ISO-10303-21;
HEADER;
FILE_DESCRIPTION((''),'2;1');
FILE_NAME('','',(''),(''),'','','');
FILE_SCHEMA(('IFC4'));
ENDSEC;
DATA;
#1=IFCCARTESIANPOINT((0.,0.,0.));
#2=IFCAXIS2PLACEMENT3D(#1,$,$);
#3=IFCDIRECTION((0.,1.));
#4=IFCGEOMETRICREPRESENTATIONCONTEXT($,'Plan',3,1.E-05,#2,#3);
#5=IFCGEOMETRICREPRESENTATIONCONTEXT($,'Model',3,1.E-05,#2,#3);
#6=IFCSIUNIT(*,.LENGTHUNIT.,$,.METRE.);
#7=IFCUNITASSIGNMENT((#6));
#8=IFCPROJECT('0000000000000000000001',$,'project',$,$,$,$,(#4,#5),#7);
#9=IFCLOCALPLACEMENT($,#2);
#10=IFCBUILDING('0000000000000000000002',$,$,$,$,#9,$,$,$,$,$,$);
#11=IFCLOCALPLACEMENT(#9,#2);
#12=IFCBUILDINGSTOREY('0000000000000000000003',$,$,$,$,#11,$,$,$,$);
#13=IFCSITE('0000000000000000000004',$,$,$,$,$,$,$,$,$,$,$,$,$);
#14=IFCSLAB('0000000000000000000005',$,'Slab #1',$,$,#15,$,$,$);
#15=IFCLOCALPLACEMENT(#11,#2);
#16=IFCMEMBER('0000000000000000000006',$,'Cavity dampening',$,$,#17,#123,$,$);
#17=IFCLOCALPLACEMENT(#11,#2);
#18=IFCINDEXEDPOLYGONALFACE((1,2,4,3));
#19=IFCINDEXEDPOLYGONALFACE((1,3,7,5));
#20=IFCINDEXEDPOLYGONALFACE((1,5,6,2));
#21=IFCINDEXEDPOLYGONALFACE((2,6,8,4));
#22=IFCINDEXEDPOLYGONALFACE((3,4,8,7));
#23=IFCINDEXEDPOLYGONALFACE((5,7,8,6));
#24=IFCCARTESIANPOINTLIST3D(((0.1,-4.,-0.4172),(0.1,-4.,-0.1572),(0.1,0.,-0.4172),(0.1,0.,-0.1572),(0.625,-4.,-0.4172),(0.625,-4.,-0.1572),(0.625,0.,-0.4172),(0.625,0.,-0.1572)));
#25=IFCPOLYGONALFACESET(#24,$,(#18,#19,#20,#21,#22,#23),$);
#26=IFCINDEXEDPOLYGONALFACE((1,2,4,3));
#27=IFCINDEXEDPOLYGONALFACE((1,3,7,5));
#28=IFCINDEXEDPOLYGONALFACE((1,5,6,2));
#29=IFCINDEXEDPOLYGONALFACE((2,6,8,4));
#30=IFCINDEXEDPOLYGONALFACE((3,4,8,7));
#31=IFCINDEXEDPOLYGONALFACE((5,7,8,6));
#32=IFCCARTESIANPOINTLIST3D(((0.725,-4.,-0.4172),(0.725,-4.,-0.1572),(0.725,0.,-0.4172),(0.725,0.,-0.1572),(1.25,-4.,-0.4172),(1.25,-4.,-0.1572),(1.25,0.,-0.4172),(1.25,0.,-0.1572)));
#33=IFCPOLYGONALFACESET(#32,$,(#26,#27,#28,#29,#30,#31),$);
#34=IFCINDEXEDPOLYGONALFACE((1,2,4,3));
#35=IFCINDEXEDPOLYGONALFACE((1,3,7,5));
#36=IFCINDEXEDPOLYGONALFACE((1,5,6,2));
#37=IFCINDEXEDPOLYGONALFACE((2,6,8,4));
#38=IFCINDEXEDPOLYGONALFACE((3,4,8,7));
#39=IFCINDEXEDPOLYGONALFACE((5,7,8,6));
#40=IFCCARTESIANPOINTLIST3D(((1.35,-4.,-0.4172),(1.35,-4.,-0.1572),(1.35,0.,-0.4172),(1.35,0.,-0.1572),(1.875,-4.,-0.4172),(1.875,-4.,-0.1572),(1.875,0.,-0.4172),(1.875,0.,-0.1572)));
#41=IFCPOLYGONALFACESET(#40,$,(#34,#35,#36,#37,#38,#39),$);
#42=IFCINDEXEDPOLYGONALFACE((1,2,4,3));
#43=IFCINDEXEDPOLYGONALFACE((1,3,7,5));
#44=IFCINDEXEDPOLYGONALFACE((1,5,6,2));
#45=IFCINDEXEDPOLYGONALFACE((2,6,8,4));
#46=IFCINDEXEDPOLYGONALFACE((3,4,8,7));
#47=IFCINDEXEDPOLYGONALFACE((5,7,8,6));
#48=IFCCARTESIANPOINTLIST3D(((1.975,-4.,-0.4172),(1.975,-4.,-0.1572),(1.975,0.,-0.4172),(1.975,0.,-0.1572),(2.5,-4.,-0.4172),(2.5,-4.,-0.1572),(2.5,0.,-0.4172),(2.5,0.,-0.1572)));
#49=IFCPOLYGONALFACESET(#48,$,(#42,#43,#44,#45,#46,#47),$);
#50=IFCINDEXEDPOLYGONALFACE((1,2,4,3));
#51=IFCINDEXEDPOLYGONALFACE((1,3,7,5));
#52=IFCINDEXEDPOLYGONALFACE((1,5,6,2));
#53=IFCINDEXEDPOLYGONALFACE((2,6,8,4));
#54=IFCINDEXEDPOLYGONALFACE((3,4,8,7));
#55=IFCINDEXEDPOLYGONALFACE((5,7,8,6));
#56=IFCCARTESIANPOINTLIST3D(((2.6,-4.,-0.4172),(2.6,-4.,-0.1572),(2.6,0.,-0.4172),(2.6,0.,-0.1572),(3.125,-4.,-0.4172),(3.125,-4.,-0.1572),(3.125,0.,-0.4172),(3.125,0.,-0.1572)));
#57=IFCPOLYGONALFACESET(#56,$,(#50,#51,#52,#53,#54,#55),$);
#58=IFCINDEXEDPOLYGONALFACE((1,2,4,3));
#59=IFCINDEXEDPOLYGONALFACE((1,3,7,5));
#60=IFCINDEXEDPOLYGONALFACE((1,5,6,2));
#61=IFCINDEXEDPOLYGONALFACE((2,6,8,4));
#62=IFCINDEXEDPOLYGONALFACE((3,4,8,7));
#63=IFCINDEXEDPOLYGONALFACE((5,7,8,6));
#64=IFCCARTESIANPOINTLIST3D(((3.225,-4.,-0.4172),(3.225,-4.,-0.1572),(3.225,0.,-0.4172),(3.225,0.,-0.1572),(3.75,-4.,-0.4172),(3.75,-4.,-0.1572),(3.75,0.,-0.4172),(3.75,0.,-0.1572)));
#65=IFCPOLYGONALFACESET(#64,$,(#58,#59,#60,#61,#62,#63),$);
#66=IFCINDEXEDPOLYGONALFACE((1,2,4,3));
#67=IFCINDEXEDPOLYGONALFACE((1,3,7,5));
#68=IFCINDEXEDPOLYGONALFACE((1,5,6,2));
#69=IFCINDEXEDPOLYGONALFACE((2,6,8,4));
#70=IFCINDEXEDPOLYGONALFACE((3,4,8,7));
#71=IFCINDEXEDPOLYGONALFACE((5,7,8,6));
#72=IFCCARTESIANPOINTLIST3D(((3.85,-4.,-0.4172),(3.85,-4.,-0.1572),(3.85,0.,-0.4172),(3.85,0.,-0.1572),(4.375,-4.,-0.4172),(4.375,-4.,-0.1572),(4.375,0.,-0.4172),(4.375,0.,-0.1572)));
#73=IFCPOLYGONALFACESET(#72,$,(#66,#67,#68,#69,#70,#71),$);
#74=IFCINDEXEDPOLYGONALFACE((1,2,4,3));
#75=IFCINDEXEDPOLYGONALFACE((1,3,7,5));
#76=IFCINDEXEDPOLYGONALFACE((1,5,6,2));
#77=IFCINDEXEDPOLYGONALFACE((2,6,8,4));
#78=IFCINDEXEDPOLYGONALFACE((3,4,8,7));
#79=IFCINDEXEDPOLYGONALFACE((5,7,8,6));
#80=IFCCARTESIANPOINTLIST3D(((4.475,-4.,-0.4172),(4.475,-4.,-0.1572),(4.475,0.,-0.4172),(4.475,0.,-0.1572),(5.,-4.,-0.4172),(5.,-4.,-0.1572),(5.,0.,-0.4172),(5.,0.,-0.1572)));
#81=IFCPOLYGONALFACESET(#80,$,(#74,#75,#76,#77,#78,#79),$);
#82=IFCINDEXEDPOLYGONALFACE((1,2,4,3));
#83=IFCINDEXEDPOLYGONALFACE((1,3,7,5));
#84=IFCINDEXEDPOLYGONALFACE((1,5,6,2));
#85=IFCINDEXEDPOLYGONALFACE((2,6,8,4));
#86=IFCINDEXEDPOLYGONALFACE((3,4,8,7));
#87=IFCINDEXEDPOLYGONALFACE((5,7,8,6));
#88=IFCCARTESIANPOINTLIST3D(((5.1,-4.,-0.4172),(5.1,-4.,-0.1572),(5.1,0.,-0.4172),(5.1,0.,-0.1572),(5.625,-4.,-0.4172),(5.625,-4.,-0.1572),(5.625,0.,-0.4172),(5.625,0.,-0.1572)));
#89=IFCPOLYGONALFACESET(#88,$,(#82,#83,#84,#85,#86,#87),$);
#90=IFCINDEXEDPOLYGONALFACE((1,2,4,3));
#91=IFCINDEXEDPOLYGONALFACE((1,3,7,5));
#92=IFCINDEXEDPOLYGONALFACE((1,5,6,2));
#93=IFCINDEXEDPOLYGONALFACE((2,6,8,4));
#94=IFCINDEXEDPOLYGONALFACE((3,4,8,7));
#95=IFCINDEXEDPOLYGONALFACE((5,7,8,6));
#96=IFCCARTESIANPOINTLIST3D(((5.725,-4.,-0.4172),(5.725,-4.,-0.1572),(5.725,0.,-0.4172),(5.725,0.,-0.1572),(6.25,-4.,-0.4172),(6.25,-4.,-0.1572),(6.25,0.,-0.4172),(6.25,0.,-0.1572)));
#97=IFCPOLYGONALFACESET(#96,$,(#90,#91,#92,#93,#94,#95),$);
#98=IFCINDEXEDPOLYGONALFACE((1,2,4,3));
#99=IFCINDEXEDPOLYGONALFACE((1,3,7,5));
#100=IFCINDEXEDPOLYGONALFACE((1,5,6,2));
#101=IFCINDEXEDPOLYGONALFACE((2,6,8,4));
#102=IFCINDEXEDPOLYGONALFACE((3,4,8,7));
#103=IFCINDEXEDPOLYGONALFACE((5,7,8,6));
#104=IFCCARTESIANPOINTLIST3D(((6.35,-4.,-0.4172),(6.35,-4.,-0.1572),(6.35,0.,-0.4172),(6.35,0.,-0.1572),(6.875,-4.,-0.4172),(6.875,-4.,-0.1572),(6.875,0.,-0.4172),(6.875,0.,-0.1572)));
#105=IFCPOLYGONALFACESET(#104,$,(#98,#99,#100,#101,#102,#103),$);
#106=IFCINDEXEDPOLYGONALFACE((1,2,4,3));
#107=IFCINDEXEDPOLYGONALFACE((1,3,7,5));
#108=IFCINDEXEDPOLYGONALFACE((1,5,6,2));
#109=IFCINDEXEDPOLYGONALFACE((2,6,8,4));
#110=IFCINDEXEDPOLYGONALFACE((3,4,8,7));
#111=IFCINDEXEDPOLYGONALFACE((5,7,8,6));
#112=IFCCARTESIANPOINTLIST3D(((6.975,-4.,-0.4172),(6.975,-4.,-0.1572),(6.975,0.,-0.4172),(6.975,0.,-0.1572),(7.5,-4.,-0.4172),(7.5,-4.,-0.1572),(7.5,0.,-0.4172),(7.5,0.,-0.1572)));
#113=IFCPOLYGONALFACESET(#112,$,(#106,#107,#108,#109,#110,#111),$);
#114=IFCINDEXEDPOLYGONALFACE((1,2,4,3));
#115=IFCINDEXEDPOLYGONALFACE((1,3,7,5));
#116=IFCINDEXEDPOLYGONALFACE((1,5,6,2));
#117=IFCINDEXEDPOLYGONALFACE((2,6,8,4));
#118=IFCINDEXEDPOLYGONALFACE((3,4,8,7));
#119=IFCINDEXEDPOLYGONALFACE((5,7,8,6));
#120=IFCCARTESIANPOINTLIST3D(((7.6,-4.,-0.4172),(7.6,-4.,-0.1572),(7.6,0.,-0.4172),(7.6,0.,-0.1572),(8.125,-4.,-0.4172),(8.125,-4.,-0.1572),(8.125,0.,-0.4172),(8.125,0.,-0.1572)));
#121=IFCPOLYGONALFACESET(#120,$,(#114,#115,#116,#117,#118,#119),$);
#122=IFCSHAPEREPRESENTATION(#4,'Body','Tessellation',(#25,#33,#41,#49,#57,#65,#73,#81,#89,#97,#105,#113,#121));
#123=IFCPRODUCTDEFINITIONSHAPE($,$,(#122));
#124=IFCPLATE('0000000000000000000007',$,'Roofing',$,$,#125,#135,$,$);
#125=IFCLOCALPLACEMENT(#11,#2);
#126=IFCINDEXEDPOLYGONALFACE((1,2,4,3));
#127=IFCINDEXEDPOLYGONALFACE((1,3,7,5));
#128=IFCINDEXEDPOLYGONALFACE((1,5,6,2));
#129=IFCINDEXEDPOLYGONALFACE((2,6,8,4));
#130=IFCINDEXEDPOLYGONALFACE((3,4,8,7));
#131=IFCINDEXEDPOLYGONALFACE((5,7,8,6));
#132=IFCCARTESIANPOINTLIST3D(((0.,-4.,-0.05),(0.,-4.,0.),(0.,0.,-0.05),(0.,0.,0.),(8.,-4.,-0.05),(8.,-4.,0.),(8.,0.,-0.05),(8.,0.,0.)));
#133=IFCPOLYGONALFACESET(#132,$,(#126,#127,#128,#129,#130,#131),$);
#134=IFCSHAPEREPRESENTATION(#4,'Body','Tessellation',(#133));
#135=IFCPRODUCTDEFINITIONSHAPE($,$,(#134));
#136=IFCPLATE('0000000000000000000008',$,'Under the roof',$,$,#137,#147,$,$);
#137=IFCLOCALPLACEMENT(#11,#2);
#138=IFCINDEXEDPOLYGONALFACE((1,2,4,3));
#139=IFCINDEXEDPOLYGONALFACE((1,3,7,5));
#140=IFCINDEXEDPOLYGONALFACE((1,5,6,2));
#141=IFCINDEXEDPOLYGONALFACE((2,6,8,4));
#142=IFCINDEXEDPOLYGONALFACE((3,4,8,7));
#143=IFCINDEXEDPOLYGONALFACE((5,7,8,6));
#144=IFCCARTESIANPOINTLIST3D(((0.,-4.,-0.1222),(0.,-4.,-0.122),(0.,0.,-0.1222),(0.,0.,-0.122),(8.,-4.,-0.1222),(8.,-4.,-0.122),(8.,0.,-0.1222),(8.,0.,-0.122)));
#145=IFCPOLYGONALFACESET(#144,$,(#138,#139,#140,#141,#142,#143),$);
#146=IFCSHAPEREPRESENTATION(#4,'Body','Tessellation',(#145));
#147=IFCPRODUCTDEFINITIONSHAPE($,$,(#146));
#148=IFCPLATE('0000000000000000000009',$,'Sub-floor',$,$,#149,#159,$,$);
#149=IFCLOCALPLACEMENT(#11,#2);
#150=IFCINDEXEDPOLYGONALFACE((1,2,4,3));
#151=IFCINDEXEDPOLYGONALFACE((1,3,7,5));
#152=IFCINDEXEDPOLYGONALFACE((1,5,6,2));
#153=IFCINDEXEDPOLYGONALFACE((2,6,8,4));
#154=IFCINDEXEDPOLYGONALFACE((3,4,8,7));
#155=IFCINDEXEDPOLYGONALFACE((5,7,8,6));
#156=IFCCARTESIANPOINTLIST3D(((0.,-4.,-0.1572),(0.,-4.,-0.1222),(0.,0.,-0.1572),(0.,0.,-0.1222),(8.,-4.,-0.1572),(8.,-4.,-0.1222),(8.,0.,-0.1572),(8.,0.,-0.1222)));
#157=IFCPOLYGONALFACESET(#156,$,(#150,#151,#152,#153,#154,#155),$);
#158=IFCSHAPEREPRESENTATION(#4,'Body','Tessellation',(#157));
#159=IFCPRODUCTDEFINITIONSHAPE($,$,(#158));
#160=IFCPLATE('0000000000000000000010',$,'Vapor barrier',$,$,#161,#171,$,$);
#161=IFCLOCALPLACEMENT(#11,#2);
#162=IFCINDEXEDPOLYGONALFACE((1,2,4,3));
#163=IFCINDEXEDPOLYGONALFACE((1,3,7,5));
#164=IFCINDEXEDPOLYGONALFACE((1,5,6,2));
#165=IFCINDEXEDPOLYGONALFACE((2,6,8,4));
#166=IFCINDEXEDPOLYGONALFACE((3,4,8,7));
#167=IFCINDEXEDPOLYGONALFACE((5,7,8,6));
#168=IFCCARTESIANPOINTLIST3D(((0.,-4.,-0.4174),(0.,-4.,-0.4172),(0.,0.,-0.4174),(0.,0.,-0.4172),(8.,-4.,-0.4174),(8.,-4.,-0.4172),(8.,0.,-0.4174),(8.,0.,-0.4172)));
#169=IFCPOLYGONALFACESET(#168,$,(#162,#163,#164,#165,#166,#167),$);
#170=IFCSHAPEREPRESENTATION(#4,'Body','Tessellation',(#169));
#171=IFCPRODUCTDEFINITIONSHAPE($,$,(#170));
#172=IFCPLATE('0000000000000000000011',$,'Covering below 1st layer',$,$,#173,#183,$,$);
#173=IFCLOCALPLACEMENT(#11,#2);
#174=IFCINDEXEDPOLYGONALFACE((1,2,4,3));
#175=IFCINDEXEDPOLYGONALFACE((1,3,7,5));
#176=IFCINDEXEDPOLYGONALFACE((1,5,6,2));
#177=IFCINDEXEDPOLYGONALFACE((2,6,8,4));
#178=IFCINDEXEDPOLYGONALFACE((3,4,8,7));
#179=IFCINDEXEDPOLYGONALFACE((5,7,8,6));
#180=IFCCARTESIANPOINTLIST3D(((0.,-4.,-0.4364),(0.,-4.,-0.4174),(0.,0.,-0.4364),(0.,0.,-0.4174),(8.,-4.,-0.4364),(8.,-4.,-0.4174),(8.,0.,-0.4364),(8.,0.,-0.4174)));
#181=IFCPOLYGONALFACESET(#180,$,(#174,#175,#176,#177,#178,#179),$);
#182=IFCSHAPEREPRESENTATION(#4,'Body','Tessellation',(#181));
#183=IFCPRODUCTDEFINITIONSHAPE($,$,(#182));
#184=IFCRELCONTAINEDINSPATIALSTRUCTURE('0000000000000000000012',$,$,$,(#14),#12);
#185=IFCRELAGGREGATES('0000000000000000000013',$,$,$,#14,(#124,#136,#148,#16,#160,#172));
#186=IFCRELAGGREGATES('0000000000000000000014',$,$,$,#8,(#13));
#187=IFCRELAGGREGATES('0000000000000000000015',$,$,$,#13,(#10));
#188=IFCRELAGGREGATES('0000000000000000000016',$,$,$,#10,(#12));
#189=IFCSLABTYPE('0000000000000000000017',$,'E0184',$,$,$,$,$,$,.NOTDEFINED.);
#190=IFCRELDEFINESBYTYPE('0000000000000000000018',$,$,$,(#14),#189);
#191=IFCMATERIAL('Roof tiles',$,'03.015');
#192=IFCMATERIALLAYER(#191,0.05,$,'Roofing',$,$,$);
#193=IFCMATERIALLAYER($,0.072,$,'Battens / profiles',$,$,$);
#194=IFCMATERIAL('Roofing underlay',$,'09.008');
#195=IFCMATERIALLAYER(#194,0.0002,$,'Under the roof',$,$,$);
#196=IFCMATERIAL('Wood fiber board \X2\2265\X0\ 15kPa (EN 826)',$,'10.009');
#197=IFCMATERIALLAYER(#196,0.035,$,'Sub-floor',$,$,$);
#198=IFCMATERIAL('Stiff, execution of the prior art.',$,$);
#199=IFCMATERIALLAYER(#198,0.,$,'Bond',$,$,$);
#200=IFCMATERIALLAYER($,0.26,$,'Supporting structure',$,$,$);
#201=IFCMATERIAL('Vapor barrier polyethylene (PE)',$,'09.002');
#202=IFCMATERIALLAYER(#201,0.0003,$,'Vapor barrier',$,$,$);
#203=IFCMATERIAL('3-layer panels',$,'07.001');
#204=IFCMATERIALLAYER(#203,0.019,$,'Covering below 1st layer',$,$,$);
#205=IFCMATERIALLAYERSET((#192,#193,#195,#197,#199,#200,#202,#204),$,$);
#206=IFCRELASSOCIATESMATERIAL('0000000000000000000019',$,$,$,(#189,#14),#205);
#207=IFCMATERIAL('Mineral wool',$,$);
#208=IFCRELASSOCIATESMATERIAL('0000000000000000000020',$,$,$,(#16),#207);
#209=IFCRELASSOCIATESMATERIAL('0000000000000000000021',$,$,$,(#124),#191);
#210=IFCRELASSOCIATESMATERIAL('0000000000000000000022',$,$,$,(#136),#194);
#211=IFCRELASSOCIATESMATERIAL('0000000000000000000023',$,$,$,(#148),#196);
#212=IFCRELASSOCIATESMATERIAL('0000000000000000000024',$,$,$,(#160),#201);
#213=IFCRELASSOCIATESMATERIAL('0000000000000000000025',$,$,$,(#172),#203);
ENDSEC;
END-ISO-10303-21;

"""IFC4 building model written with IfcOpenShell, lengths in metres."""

from ifc_helpers import new_model, si_unit, direction, frame, frame_2d, origin, origin_with_axes, place, context, project, spatial, rectangle, extrude, material, layer, layer_set, type_object, element, aggregate, save


model = new_model("IFC4")

# Units and contexts
plan_context = context("Plan", 3, precision=1e-05, world=origin(), true_north=direction((0.0, 1.0)))
model_context = context("Model", 3, precision=1e-05, world=origin(), true_north=direction((0.0, 1.0)))
ifc_project = project(units=[si_unit("LENGTHUNIT", "METRE")], contexts=[plan_context, model_context])

# Site, building, storey
site = spatial("IfcSite", under=ifc_project)
building_placement = place(None, origin())
building = spatial("IfcBuilding", under=site, at=building_placement)
storey_placement = place(building_placement, origin())
storey = spatial("IfcBuildingStorey", under=building, at=storey_placement)

# Slab, member, plates
ifc_material_1 = material(Name="Roof tiles", Category="03.015")
ifc_layer_1 = layer(ifc_material_1, 0.05, Name="Roofing")
ifc_layer_2 = layer(None, 0.072, Name="Battens / profiles")
ifc_material_2 = material(Name="Roofing underlay", Category="09.008")
ifc_layer_3 = layer(ifc_material_2, 0.0002, Name="Under the roof")
ifc_material_3 = material(Name="Wood fiber board ≥ 15kPa (EN 826)", Category="10.009")
ifc_layer_4 = layer(ifc_material_3, 0.035, Name="Sub-floor")
ifc_material_4 = material(Name="Stiff, execution of the prior art.")
ifc_layer_5 = layer(ifc_material_4, 0.0, Name="Bond")
ifc_layer_6 = layer(None, 0.26, Name="Supporting structure")
ifc_material_5 = material(Name="Vapor barrier polyethylene (PE)", Category="09.002")
ifc_layer_7 = layer(ifc_material_5, 0.0003, Name="Vapor barrier")
ifc_material_6 = material(Name="3-layer panels", Category="07.001")
ifc_layer_8 = layer(ifc_material_6, 0.019, Name="Covering below 1st layer")
ifc_layer_set = layer_set([ifc_layer_1, ifc_layer_2, ifc_layer_3, ifc_layer_4, ifc_layer_5, ifc_layer_6, ifc_layer_7, ifc_layer_8])
slab_type = type_object("IfcSlabType", Name="E0184", PredefinedType="NOTDEFINED", material=ifc_layer_set)
slab_placement = place(None, frame((0.0, 0.0, 0.0), z_axis=(0.0, 0.0, -1.0), x_axis=(1.0, 0.0, 0.0)))
slab = element("IfcSlab", 1, at=slab_placement, inside=storey, type_object=slab_type, material=ifc_layer_set, Name="Slab #1")
ifc_material_7 = material(Name="Mineral wool")
member_1_placement = place(slab_placement, origin())
member_1 = element("IfcMember", 2, at=member_1_placement, material=ifc_material_7, Name="Cavity dampening", context=plan_context, shape_type="SweptSolid", body=[
    extrude(rectangle(XDim=0.525, YDim=0.26, at=frame_2d((0.2625, 0.13), x_axis=(1.0, 0.0))), frame((0.1, 4.0, 0.1572), z_axis=(0.0, -1.0, 0.0), x_axis=(1.0, 0.0, 0.0)), (0.0, 0.0, 1.0), 4.0),
    extrude(rectangle(XDim=0.525, YDim=0.26, at=frame_2d((0.2625, 0.13), x_axis=(1.0, 0.0))), frame((0.725, 4.0, 0.1572), z_axis=(0.0, -1.0, 0.0), x_axis=(1.0, 0.0, 0.0)), (0.0, 0.0, 1.0), 4.0),
    extrude(rectangle(XDim=0.525, YDim=0.26, at=frame_2d((0.2625, 0.13), x_axis=(1.0, 0.0))), frame((1.35, 4.0, 0.1572), z_axis=(0.0, -1.0, 0.0), x_axis=(1.0, 0.0, 0.0)), (0.0, 0.0, 1.0), 4.0),
    extrude(rectangle(XDim=0.525, YDim=0.26, at=frame_2d((0.2625, 0.13), x_axis=(1.0, 0.0))), frame((1.975, 4.0, 0.1572), z_axis=(0.0, -1.0, 0.0), x_axis=(1.0, 0.0, 0.0)), (0.0, 0.0, 1.0), 4.0),
    extrude(rectangle(XDim=0.525, YDim=0.26, at=frame_2d((0.2625, 0.13), x_axis=(1.0, 0.0))), frame((2.6, 4.0, 0.1572), z_axis=(0.0, -1.0, 0.0), x_axis=(1.0, 0.0, 0.0)), (0.0, 0.0, 1.0), 4.0),
    extrude(rectangle(XDim=0.525, YDim=0.26, at=frame_2d((0.2625, 0.13), x_axis=(1.0, 0.0))), frame((3.225, 4.0, 0.1572), z_axis=(0.0, -1.0, 0.0), x_axis=(1.0, 0.0, 0.0)), (0.0, 0.0, 1.0), 4.0),
    extrude(rectangle(XDim=0.525, YDim=0.26, at=frame_2d((0.2625, 0.13), x_axis=(1.0, 0.0))), frame((3.85, 4.0, 0.1572), z_axis=(0.0, -1.0, 0.0), x_axis=(1.0, 0.0, 0.0)), (0.0, 0.0, 1.0), 4.0),
    extrude(rectangle(XDim=0.525, YDim=0.26, at=frame_2d((0.2625, 0.13), x_axis=(1.0, 0.0))), frame((4.475, 4.0, 0.1572), z_axis=(0.0, -1.0, 0.0), x_axis=(1.0, 0.0, 0.0)), (0.0, 0.0, 1.0), 4.0),
    extrude(rectangle(XDim=0.525, YDim=0.26, at=frame_2d((0.2625, 0.13), x_axis=(1.0, 0.0))), frame((5.1, 4.0, 0.1572), z_axis=(0.0, -1.0, 0.0), x_axis=(1.0, 0.0, 0.0)), (0.0, 0.0, 1.0), 4.0),
    extrude(rectangle(XDim=0.525, YDim=0.26, at=frame_2d((0.2625, 0.13), x_axis=(1.0, 0.0))), frame((5.725, 4.0, 0.1572), z_axis=(0.0, -1.0, 0.0), x_axis=(1.0, 0.0, 0.0)), (0.0, 0.0, 1.0), 4.0),
    extrude(rectangle(XDim=0.525, YDim=0.26, at=frame_2d((0.2625, 0.13), x_axis=(1.0, 0.0))), frame((6.35, 4.0, 0.1572), z_axis=(0.0, -1.0, 0.0), x_axis=(1.0, 0.0, 0.0)), (0.0, 0.0, 1.0), 4.0),
    extrude(rectangle(XDim=0.525, YDim=0.26, at=frame_2d((0.2625, 0.13), x_axis=(1.0, 0.0))), frame((6.975, 4.0, 0.1572), z_axis=(0.0, -1.0, 0.0), x_axis=(1.0, 0.0, 0.0)), (0.0, 0.0, 1.0), 4.0),
    extrude(rectangle(XDim=0.525, YDim=0.26, at=frame_2d((0.2625, 0.13), x_axis=(1.0, 0.0))), frame((7.6, 4.0, 0.1572), z_axis=(0.0, -1.0, 0.0), x_axis=(1.0, 0.0, 0.0)), (0.0, 0.0, 1.0), 4.0),
])
plate_1_placement = place(slab_placement, origin())
plate_1 = element("IfcPlate", 3, at=plate_1_placement, material=ifc_material_1, Name="Roofing", context=plan_context, shape_type="SweptSolid", body=[
    extrude(rectangle(XDim=8.0, YDim=4.0, at=frame_2d((4.0, 2.0), x_axis=(1.0, 0.0))), origin_with_axes(), (0.0, 0.0, 1.0), 0.05),
])
plate_2_placement = place(slab_placement, origin())
plate_2 = element("IfcPlate", 4, at=plate_2_placement, material=ifc_material_2, Name="Under the roof", context=plan_context, shape_type="SweptSolid", body=[
    extrude(rectangle(XDim=8.0, YDim=4.0, at=frame_2d((4.0, 2.0), x_axis=(1.0, 0.0))), frame((0.0, 0.0, 0.122), z_axis=(0.0, 0.0, 1.0), x_axis=(1.0, 0.0, 0.0)), (0.0, 0.0, 1.0), 0.0002),
])
plate_3_placement = place(slab_placement, origin())
plate_3 = element("IfcPlate", 5, at=plate_3_placement, material=ifc_material_3, Name="Sub-floor", context=plan_context, shape_type="SweptSolid", body=[
    extrude(rectangle(XDim=8.0, YDim=4.0, at=frame_2d((4.0, 2.0), x_axis=(1.0, 0.0))), frame((0.0, 0.0, 0.1222), z_axis=(0.0, 0.0, 1.0), x_axis=(1.0, 0.0, 0.0)), (0.0, 0.0, 1.0), 0.035),
])
plate_4_placement = place(slab_placement, origin())
plate_4 = element("IfcPlate", 6, at=plate_4_placement, material=ifc_material_5, Name="Vapor barrier", context=plan_context, shape_type="SweptSolid", body=[
    extrude(rectangle(XDim=8.0, YDim=4.0, at=frame_2d((4.0, 2.0), x_axis=(1.0, 0.0))), frame((0.0, 0.0, 0.4172), z_axis=(0.0, 0.0, 1.0), x_axis=(1.0, 0.0, 0.0)), (0.0, 0.0, 1.0), 0.0003),
])
plate_5_placement = place(slab_placement, origin())
plate_5 = element("IfcPlate", 7, at=plate_5_placement, material=ifc_material_6, Name="Covering below 1st layer", context=plan_context, shape_type="SweptSolid", body=[
    extrude(rectangle(XDim=8.0, YDim=4.0, at=frame_2d((4.0, 2.0), x_axis=(1.0, 0.0))), frame((0.0, 0.0, 0.4174), z_axis=(0.0, 0.0, 1.0), x_axis=(1.0, 0.0, 0.0)), (0.0, 0.0, 1.0), 0.019),
])
aggregate(slab, [plate_1, plate_2, plate_3, member_1, plate_4, plate_5])

save(model, "model.ifc")
